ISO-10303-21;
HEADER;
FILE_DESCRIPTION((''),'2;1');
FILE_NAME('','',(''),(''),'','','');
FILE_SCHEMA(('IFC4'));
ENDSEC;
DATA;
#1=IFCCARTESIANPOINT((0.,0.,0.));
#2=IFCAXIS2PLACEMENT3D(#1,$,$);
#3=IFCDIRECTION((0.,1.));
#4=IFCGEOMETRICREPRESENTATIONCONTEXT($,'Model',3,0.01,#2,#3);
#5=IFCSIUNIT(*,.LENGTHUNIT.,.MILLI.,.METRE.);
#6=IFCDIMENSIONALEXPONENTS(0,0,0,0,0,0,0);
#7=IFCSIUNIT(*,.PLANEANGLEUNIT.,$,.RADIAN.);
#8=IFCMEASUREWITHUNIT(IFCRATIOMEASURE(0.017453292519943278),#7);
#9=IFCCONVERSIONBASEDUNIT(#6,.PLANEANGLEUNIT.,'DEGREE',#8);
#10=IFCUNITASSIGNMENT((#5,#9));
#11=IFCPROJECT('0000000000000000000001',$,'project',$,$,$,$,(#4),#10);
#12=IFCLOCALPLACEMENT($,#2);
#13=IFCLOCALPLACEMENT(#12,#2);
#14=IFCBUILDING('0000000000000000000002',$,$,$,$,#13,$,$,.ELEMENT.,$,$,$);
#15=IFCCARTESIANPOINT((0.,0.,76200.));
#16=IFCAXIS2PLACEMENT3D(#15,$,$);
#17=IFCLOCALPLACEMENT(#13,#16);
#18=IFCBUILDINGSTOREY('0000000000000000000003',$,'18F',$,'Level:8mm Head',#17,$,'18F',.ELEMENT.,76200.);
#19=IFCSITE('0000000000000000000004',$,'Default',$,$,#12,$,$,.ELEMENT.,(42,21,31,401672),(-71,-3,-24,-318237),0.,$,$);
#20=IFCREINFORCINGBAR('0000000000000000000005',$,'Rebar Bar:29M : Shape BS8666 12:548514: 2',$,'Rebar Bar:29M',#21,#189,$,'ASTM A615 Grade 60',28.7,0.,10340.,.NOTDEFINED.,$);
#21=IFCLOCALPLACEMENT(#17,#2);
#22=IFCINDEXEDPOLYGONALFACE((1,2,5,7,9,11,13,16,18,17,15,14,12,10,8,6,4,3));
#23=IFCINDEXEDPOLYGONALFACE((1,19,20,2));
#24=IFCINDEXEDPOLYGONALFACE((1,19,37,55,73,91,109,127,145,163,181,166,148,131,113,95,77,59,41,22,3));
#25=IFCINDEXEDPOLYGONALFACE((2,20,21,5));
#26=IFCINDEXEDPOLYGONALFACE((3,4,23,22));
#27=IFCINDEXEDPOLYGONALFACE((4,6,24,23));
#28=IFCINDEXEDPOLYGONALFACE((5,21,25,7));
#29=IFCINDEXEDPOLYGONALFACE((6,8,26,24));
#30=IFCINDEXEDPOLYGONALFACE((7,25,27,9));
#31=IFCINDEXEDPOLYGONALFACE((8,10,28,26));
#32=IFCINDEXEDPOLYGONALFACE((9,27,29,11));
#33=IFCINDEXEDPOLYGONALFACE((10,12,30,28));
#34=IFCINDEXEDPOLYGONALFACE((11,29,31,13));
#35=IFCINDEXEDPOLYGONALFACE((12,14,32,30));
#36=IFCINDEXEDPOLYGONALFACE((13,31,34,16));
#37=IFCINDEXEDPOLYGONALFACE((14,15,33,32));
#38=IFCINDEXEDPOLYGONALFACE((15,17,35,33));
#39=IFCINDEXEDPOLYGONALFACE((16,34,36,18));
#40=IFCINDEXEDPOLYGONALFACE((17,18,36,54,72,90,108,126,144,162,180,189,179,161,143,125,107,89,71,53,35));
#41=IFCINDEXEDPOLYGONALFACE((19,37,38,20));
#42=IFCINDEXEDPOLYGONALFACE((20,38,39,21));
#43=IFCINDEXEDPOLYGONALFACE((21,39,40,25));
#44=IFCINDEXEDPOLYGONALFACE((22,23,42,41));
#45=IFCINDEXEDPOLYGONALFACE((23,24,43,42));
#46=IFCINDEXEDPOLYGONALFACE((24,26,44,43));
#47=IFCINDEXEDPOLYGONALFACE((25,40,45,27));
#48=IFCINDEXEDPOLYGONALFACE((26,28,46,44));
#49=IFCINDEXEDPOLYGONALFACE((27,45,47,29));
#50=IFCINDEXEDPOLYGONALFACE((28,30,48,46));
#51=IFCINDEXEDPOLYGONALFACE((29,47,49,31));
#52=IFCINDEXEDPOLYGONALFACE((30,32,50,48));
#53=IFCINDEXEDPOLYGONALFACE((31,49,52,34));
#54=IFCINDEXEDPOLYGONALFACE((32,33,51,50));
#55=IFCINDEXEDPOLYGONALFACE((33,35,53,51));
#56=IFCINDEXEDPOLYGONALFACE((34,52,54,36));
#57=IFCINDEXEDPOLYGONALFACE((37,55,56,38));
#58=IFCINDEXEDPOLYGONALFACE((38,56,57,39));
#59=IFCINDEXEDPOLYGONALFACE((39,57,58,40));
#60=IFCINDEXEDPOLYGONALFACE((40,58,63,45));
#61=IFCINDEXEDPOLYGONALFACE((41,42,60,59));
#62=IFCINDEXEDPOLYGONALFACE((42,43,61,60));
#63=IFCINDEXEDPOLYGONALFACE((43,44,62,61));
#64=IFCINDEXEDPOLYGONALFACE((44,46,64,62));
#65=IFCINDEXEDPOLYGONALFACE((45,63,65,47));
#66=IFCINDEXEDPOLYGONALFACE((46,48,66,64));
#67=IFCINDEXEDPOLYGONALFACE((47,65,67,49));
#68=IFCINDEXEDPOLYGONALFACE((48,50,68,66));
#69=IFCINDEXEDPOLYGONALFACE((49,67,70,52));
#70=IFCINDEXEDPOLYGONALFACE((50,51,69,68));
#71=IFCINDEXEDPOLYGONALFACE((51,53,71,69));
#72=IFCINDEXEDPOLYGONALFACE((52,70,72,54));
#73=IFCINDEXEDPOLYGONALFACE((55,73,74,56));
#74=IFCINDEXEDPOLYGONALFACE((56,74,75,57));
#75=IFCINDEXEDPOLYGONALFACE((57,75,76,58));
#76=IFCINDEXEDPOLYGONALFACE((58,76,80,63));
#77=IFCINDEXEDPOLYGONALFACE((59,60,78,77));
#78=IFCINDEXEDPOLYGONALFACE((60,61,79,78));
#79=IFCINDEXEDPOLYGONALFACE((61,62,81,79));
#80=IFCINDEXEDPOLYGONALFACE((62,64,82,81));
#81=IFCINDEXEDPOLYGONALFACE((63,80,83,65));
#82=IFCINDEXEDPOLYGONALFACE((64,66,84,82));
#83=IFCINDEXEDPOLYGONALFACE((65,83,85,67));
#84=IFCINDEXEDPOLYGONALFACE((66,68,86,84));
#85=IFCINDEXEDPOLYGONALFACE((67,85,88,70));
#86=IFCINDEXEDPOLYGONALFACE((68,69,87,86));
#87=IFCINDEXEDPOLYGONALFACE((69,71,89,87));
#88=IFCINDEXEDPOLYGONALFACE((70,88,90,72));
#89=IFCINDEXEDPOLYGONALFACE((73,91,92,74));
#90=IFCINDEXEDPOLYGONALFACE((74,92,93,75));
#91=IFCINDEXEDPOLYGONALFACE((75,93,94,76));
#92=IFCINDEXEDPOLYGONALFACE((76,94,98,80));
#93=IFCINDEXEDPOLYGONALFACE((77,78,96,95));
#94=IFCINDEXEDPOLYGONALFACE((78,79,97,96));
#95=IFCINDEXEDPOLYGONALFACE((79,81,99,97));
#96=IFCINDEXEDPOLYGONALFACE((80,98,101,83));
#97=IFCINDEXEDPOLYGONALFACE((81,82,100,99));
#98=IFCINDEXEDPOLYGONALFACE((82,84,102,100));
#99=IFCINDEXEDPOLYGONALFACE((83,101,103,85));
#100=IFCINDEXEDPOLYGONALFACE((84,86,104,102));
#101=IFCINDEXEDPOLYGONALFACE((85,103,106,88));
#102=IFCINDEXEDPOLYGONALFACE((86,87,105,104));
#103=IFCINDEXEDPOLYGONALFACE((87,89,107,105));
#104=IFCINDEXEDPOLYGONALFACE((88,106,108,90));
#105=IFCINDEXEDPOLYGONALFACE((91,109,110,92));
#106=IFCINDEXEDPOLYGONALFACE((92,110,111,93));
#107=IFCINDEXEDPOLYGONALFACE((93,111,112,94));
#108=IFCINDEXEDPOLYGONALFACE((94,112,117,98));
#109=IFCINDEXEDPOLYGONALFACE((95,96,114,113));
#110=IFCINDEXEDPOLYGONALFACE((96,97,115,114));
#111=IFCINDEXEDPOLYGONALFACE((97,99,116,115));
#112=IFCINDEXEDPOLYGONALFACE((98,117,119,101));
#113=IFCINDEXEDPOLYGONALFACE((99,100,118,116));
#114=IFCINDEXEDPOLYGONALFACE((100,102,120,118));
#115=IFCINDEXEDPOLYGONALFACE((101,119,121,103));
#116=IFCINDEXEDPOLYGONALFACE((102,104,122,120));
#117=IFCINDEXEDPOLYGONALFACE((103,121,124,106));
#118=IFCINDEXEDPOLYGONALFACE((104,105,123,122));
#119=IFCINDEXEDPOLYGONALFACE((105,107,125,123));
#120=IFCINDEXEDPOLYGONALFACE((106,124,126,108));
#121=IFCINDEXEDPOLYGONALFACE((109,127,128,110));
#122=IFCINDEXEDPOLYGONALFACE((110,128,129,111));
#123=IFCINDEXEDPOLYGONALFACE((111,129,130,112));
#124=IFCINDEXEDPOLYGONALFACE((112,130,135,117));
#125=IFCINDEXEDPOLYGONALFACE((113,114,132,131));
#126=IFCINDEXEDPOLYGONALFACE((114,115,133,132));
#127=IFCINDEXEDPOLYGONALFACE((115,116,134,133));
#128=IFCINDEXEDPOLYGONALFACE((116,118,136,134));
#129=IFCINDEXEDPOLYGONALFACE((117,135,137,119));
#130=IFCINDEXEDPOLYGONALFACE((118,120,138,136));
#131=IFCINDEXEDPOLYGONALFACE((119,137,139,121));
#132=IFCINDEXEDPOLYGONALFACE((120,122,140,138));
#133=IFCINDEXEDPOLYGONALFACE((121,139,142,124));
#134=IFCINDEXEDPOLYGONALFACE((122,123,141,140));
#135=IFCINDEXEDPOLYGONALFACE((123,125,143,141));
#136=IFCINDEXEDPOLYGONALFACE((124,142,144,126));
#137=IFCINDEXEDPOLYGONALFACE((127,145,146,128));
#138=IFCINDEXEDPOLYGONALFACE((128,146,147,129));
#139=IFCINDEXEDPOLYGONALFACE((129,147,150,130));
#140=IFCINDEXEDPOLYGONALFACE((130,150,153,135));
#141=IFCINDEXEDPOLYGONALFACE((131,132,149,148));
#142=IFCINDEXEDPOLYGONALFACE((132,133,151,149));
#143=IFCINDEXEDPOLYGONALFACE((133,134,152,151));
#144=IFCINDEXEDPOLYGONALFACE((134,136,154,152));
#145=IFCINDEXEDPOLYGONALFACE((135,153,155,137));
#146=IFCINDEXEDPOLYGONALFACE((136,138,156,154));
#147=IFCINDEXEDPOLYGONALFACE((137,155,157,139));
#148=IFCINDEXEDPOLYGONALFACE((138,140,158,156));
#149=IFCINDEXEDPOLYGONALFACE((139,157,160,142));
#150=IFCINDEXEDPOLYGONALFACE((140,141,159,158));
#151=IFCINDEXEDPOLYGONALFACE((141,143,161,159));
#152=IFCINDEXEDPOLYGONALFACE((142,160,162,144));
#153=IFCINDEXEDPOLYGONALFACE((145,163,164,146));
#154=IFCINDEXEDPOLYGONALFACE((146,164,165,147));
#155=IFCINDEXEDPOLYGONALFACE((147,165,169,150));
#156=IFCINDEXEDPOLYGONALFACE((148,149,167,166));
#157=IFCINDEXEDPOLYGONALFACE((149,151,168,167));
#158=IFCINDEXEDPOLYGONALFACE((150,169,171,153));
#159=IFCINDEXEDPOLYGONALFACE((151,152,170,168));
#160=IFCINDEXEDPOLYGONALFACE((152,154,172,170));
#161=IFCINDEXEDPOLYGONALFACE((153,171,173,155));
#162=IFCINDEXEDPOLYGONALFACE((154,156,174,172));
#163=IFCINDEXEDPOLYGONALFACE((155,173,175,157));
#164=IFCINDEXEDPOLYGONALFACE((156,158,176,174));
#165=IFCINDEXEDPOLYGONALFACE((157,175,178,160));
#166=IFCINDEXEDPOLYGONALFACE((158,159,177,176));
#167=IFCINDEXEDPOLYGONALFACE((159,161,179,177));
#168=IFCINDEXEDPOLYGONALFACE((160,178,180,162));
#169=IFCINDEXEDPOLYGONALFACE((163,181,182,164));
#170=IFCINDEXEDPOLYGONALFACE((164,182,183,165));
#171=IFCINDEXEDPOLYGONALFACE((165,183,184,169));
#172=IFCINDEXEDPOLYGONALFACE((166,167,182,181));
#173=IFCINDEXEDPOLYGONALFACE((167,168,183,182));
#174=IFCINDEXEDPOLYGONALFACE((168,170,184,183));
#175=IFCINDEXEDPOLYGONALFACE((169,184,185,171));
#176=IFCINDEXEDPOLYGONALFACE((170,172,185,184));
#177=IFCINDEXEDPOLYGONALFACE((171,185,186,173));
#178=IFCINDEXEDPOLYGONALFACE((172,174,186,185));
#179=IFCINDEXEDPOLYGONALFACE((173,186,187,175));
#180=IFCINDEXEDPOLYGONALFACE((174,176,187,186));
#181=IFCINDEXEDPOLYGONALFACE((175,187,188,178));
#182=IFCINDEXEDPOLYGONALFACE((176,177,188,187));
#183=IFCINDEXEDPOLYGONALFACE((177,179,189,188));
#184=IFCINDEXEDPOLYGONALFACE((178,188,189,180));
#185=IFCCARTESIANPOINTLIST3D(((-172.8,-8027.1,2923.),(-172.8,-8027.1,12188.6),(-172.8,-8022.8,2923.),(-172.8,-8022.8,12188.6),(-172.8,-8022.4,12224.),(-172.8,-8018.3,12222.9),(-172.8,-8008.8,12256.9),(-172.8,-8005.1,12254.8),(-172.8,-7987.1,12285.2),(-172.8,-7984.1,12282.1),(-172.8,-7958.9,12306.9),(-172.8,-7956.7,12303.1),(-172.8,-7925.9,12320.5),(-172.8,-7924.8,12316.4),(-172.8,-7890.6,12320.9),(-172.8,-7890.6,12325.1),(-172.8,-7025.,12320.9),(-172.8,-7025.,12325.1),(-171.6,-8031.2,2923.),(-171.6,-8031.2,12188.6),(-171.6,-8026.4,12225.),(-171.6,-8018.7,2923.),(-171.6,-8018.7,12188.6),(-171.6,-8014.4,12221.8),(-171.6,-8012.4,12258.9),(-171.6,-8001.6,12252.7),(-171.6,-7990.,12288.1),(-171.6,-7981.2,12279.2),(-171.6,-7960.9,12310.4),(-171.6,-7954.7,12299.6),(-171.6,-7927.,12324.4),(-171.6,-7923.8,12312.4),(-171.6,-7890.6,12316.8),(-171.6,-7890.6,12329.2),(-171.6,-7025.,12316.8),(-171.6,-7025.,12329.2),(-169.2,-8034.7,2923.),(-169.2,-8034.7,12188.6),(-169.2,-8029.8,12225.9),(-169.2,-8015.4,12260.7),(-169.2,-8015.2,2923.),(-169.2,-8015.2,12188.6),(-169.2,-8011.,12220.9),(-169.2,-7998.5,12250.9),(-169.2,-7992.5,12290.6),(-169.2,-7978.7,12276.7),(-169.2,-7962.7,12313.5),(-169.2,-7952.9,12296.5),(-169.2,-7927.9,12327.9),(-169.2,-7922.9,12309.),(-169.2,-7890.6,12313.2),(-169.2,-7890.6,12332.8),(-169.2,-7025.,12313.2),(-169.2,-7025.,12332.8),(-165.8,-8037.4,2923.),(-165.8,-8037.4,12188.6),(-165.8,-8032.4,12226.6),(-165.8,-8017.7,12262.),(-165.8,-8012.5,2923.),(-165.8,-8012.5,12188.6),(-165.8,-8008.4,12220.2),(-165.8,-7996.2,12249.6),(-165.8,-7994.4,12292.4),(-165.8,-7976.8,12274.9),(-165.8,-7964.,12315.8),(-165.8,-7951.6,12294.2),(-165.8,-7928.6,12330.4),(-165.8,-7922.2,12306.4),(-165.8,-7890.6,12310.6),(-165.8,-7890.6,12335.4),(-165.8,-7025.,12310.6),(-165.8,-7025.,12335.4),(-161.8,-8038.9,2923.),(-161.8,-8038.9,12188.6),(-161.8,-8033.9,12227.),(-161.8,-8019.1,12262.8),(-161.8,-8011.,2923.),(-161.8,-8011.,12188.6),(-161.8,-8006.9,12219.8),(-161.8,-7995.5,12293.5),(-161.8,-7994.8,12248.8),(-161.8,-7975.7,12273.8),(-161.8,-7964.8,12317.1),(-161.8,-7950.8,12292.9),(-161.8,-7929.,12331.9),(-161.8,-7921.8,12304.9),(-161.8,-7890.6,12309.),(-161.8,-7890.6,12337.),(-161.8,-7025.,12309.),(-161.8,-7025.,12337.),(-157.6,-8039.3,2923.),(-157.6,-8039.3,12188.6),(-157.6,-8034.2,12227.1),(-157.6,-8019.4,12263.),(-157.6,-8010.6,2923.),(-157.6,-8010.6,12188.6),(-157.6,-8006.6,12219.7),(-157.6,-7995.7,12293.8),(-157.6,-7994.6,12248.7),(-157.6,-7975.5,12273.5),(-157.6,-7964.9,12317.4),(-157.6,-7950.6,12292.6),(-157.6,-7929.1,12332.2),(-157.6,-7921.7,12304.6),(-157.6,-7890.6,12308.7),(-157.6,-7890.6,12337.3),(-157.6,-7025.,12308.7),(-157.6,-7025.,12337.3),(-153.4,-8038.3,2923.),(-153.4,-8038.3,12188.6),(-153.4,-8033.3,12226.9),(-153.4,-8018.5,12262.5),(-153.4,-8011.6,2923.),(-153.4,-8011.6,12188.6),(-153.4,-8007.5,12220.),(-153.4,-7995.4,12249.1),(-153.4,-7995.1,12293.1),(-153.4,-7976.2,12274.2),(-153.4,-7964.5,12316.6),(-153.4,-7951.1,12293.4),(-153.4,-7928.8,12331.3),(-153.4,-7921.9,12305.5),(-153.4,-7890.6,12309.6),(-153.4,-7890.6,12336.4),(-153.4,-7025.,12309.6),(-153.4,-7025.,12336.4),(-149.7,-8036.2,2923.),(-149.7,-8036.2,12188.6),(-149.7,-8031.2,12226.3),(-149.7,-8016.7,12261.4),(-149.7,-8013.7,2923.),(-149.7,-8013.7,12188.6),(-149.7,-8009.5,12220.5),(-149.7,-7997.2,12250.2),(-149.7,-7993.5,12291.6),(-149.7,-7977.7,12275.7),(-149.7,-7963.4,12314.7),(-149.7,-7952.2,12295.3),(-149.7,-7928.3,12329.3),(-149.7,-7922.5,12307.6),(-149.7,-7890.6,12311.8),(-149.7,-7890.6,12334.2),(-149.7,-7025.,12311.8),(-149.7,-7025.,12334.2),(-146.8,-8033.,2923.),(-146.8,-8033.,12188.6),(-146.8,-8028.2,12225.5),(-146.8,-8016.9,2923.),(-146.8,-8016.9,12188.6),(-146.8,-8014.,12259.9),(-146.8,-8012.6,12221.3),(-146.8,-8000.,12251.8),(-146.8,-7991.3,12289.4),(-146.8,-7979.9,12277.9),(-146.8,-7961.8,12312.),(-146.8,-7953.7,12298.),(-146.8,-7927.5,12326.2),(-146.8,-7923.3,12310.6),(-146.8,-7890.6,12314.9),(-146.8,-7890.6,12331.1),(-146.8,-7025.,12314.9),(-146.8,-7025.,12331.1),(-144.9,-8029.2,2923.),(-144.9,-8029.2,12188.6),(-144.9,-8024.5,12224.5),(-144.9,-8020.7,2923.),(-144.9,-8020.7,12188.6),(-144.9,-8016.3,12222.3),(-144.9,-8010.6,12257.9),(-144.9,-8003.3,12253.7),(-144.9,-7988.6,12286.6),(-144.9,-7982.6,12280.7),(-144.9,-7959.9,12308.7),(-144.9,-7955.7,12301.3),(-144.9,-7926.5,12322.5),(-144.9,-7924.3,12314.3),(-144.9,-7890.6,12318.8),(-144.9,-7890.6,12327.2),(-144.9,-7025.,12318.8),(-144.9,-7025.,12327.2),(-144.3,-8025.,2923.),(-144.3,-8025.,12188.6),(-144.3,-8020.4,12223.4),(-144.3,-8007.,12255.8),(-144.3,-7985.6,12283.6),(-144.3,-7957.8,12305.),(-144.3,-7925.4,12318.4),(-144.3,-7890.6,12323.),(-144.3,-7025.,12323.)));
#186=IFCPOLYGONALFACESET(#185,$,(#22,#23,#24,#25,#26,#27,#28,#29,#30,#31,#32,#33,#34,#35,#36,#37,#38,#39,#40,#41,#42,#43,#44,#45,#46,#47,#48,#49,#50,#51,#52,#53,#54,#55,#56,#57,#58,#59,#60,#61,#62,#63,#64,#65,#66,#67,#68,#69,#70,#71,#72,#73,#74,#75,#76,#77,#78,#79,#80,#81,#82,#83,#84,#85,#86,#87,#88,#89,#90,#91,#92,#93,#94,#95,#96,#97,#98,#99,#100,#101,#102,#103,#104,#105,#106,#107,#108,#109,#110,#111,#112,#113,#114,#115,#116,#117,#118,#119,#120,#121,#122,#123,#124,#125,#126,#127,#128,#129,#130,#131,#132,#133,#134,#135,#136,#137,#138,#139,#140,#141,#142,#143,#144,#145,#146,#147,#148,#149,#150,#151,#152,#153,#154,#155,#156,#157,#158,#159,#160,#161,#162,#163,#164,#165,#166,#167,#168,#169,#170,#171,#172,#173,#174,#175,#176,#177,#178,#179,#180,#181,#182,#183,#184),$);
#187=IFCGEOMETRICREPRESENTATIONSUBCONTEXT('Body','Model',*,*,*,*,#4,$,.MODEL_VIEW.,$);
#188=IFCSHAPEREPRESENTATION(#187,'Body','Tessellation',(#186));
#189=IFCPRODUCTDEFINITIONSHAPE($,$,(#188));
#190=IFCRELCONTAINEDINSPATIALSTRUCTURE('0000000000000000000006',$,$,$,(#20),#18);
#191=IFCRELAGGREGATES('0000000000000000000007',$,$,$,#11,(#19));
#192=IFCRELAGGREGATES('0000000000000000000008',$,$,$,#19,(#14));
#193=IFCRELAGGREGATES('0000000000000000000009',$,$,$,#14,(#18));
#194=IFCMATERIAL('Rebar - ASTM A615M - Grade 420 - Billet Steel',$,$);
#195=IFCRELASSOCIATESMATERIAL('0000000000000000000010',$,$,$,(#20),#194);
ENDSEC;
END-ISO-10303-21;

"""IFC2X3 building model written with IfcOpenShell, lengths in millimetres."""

from ifc_helpers import new_model, entity, si_unit, converted_unit, direction, frame, origin, place, context, subcontext, project, spatial, material, element, save


model = new_model("IFC2X3")

# Units and contexts
model_context = context("Model", 3, precision=0.01, world=origin(), true_north=direction((0.0, 1.0)))
body_context = subcontext(model_context, "Body", "Model", "MODEL_VIEW")
ifc_project = project(units=[si_unit("LENGTHUNIT", "METRE", prefix="MILLI"), converted_unit("PLANEANGLEUNIT", "DEGREE", entity("IfcRatioMeasure", 0.017453292519943278), si_unit("PLANEANGLEUNIT", "RADIAN"), dimensions=[0, 0, 0, 0, 0, 0, 0])], contexts=[model_context])

# Site, building, storey
site_placement = place(None, origin())
site = spatial("IfcSite", under=ifc_project, at=site_placement, Name="Default", CompositionType="ELEMENT", RefLatitude=(42, 21, 31, 401672), RefLongitude=(-71, -3, -24, -318237), RefElevation=0.0)
building_placement = place(site_placement, origin())
building = spatial("IfcBuilding", under=site, at=building_placement, CompositionType="ELEMENT")
storey_placement = place(building_placement, frame((0.0, 0.0, 76200.0)))
storey = spatial("IfcBuildingStorey", under=building, at=storey_placement, Name="18F", ObjectType="Level:8mm Head", LongName="18F", CompositionType="ELEMENT", Elevation=76200.0)

# Reinforcing bar
ifc_material_1 = material(Name="Rebar - ASTM A615M - Grade 420 - Billet Steel")
reinforcing_bar_1_placement = place(storey_placement, origin())
element("IfcReinforcingBar", 1, at=reinforcing_bar_1_placement, inside=storey, material=ifc_material_1, Name="Rebar Bar:29M : Shape BS8666 12:548514: 2", SteelGrade="ASTM A615 Grade 60", ObjectType="Rebar Bar:29M", BarLength=10340.0, BarRole="NOTDEFINED", CrossSectionArea=0.0, NominalDiameter=28.7, context=body_context, shape_type="AdvancedSweptSolid", body=[
    entity("IfcSweptDiskSolid", entity("IfcCompositeCurve", [entity("IfcCompositeCurveSegment", "CONTINUOUS", True, entity("IfcPolyline", [entity("IfcCartesianPoint", [-158.6, -8025.0, 2923.0]), entity("IfcCartesianPoint", [-158.6, -8025.0, 12188.6])])), entity("IfcCompositeCurveSegment", "CONTINUOUS", True, entity("IfcTrimmedCurve", entity("IfcCircle", entity("IfcAxis2Placement3D", entity("IfcCartesianPoint", [-158.6, -7890.6, 12188.6]), entity("IfcDirection", [-1.0, 0.0, 0.0]), entity("IfcDirection", [0.0, 0.0, 1.0])), 134.3), [entity("IfcParameterValue", 270.0)], [entity("IfcParameterValue", 360.0)], True, "PARAMETER")), entity("IfcCompositeCurveSegment", "CONTINUOUS", True, entity("IfcPolyline", [entity("IfcCartesianPoint", [-158.6, -7890.6, 12323.0]), entity("IfcCartesianPoint", [-158.6, -7025.0, 12323.0])]))], False), 14.3, None, 0.0, 92.0),
])

save(model, "model.ifc")
